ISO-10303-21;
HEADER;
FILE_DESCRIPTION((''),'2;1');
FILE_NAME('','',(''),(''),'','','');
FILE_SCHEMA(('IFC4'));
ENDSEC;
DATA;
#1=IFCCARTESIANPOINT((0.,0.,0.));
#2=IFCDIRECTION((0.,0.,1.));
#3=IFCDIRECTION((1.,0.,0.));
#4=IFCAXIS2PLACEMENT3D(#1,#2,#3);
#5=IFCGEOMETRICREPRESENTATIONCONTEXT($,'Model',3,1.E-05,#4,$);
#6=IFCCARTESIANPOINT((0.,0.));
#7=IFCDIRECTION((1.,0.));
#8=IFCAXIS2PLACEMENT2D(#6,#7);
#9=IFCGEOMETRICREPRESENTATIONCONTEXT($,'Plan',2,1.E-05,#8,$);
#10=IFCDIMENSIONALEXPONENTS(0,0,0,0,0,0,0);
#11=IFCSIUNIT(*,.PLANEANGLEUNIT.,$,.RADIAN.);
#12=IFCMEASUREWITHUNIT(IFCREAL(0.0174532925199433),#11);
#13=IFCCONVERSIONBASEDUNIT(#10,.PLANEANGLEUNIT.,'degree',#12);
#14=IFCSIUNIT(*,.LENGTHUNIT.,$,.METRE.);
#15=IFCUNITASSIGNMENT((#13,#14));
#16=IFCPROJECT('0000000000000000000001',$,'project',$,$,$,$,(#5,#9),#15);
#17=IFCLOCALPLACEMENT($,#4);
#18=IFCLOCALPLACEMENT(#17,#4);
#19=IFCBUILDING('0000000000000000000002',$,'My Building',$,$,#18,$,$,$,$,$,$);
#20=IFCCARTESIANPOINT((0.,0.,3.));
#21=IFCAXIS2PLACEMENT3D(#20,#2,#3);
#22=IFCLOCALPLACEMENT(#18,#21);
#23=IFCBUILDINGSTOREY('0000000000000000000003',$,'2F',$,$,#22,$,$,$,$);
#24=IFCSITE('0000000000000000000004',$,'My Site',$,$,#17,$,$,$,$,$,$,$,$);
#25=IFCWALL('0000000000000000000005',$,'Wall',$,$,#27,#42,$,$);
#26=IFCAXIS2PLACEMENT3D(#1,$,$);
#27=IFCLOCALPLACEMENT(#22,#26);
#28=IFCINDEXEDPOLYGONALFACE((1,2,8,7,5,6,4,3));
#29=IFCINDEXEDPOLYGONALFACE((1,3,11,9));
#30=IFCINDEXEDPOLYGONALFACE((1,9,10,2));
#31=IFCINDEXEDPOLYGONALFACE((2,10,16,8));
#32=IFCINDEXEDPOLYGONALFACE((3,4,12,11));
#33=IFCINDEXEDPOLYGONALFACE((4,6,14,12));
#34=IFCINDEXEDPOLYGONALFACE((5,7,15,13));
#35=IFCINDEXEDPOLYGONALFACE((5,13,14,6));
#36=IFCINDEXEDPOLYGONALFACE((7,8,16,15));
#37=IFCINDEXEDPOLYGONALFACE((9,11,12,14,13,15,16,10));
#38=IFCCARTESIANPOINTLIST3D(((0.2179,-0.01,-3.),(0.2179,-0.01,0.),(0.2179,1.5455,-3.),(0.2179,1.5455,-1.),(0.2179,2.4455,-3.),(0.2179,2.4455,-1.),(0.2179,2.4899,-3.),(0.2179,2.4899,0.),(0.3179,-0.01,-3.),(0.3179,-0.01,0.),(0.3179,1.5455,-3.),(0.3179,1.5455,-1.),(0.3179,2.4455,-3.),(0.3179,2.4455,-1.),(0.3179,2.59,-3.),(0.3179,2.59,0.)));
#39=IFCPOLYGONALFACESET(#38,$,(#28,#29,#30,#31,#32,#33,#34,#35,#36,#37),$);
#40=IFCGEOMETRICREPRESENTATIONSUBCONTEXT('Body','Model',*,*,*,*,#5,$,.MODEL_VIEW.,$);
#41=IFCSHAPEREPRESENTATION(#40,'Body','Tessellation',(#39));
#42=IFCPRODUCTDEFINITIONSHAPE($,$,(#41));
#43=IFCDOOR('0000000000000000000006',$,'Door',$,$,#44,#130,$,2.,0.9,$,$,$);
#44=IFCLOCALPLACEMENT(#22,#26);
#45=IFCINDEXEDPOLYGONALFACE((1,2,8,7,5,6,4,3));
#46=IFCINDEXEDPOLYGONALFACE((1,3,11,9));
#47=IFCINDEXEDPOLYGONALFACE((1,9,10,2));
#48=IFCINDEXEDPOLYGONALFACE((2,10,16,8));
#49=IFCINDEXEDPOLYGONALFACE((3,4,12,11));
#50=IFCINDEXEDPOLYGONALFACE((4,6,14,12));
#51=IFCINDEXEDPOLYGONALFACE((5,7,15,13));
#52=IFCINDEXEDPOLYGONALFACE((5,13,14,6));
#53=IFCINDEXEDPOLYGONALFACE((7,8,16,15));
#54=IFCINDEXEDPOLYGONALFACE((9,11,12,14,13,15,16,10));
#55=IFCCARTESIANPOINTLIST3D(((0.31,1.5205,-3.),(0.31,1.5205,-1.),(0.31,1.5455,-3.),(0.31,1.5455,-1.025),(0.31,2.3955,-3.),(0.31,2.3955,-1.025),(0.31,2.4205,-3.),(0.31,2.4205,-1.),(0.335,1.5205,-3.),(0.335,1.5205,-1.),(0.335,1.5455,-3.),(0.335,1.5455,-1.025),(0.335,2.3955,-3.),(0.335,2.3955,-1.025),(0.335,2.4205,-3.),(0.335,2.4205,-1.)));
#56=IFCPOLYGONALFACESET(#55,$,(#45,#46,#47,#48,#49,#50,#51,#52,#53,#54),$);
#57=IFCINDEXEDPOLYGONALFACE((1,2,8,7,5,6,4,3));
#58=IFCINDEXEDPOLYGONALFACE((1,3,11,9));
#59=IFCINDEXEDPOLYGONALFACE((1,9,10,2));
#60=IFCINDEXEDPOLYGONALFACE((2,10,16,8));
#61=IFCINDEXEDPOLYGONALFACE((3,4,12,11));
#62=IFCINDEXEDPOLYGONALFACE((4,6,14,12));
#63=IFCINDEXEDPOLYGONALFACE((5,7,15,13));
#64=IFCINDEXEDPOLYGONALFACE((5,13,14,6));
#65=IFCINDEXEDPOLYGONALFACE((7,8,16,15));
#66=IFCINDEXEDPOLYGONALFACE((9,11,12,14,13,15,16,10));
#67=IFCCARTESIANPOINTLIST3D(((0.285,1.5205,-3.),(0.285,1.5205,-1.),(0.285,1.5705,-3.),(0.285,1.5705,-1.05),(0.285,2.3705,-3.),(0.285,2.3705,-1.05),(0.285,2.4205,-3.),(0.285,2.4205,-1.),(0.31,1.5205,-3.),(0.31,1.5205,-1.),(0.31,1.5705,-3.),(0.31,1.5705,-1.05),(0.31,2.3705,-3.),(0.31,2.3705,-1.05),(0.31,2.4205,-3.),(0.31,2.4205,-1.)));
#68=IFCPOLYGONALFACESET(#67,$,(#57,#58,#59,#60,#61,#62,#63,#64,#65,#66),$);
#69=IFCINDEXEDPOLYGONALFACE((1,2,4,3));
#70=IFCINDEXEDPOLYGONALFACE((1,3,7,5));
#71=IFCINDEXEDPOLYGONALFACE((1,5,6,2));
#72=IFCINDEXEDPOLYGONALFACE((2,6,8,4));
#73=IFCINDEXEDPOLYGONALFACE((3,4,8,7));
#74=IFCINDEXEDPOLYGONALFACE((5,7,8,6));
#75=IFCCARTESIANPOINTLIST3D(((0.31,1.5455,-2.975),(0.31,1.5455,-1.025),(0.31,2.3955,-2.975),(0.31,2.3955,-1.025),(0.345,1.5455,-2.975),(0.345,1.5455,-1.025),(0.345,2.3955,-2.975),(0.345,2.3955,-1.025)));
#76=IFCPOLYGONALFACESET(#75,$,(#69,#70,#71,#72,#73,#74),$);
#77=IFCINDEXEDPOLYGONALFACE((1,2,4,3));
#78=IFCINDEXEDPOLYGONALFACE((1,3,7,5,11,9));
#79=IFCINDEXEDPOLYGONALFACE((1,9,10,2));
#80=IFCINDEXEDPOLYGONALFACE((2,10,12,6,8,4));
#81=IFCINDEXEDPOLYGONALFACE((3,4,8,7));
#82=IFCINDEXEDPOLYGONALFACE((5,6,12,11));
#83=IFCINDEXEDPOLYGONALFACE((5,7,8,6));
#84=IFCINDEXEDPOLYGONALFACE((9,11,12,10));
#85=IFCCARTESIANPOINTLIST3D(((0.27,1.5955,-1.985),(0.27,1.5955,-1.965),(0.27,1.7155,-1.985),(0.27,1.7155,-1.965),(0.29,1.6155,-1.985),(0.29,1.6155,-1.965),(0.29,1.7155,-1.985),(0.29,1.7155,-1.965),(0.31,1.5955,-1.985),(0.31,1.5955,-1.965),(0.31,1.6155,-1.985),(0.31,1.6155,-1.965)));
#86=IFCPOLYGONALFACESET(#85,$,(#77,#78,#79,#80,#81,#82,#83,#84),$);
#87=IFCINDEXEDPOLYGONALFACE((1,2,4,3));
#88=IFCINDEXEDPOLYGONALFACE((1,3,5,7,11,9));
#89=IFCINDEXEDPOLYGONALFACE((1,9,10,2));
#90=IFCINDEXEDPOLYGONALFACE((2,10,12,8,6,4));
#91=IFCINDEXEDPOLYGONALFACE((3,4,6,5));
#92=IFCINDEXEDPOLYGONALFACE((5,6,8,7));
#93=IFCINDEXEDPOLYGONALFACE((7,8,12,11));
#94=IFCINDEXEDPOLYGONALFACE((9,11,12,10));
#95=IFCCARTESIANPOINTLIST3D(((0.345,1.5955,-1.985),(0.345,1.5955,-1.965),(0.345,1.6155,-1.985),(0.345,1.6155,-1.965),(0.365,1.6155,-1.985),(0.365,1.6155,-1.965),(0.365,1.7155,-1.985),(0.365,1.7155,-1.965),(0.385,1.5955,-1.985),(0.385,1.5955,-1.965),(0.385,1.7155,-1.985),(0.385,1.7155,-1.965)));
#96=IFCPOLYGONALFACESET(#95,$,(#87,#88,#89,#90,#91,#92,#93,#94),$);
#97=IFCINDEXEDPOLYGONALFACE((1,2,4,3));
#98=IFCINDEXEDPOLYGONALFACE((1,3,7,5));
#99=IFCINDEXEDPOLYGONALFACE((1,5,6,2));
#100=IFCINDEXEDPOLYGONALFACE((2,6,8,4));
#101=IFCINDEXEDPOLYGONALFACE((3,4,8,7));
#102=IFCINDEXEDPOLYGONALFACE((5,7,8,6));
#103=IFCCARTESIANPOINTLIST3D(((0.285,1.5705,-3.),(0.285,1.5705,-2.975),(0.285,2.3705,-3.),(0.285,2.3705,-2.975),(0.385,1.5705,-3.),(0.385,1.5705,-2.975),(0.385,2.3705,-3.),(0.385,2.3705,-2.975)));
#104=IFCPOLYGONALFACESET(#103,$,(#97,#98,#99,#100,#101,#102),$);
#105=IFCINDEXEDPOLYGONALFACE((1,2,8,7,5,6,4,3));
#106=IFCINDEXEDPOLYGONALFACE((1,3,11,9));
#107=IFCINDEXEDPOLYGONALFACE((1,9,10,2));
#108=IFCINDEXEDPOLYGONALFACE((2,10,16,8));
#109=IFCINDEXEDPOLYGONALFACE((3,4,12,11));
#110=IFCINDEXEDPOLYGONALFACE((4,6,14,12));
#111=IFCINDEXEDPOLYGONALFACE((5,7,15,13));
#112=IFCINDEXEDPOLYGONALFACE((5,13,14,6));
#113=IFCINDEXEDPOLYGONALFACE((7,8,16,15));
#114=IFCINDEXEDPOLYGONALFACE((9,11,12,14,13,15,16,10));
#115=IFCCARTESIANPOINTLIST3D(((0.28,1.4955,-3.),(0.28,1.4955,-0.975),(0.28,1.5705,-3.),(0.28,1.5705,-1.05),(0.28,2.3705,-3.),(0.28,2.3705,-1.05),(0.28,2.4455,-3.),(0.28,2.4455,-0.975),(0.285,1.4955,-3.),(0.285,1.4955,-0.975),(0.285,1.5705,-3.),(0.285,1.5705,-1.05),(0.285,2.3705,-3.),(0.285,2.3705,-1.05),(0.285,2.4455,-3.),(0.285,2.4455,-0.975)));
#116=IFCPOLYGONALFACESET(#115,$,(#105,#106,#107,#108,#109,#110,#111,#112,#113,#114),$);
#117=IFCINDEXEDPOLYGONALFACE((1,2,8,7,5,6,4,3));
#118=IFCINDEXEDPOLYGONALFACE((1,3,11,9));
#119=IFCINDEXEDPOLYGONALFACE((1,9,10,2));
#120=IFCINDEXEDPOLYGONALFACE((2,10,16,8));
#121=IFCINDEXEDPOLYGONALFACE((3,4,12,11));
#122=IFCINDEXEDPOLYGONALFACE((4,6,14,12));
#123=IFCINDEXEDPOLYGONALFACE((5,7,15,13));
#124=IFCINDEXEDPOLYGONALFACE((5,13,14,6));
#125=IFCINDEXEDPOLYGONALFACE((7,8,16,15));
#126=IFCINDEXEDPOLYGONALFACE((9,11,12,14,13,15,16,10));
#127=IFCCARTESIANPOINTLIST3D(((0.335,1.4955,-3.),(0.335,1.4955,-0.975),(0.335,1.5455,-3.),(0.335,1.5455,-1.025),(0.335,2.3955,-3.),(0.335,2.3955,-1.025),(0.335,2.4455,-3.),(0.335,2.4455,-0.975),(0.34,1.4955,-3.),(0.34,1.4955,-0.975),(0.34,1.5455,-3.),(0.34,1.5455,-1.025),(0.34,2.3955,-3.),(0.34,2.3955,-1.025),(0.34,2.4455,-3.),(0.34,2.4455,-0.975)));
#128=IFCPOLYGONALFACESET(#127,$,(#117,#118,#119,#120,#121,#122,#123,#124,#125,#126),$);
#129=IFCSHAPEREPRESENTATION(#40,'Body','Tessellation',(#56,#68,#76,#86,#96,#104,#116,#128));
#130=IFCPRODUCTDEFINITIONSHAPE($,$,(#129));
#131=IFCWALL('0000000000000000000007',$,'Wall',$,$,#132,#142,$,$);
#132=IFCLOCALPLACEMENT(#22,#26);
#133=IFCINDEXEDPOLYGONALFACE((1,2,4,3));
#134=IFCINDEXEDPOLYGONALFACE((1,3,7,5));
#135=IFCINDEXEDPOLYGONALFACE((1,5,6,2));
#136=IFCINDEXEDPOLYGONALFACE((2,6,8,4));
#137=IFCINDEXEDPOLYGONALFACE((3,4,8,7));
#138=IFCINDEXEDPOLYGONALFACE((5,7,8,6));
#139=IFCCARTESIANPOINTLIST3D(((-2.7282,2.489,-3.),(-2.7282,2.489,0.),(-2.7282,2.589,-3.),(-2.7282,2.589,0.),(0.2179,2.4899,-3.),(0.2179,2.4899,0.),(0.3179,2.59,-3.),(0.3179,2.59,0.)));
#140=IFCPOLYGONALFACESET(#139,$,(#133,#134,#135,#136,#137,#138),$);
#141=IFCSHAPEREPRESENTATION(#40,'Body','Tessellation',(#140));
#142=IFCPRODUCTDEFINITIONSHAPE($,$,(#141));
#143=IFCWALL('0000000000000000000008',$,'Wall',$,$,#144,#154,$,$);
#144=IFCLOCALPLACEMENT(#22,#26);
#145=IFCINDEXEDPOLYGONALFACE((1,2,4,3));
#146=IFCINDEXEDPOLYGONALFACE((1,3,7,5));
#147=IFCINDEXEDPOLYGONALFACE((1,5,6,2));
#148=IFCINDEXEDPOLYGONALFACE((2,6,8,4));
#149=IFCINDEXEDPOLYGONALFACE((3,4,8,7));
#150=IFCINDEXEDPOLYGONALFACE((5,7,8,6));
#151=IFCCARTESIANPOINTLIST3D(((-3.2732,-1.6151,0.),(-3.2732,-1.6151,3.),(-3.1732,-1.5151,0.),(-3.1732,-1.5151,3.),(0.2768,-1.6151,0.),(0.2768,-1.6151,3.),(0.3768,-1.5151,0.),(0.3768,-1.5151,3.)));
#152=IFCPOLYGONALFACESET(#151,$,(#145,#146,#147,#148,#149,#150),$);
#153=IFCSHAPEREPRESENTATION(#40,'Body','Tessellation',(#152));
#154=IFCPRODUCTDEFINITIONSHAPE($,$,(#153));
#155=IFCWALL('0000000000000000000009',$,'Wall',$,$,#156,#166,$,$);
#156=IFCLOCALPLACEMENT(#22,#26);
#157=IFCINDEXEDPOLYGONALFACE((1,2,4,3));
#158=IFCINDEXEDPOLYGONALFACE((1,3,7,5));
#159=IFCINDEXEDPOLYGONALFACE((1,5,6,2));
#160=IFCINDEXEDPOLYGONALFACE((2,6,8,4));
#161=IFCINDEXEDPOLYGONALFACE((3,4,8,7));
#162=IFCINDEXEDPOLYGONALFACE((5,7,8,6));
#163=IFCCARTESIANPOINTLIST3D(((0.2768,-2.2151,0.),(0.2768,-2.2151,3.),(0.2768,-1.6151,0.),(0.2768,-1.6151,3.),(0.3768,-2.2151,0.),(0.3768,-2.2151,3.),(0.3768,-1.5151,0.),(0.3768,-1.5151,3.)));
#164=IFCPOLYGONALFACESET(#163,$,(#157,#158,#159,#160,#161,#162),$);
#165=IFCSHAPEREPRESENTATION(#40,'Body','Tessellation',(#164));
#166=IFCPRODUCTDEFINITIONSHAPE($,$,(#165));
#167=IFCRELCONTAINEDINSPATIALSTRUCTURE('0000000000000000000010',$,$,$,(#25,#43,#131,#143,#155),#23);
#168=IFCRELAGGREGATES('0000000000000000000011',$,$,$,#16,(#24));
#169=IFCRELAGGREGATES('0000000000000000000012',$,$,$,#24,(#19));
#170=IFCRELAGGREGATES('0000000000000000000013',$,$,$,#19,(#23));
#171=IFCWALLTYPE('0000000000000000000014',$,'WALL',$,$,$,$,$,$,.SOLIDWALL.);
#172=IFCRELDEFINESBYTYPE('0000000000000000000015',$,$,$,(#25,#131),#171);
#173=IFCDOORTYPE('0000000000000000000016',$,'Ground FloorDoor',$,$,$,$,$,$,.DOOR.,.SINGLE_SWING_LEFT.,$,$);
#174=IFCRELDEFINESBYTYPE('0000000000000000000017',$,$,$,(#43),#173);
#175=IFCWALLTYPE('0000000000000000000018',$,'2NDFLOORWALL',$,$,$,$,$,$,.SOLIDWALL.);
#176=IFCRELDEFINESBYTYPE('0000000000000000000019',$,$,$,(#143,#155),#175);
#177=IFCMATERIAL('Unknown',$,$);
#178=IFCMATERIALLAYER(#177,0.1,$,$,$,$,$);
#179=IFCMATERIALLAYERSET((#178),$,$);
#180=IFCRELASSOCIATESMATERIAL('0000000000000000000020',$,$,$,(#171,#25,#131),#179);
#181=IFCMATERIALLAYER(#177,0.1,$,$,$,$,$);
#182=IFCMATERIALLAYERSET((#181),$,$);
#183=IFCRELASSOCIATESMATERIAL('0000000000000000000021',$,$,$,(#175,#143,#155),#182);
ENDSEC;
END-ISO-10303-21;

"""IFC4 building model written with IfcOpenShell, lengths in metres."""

from ifc_helpers import new_model, entity, si_unit, converted_unit, frame, origin_with_axes, origin_2d_with_axis, place, context, subcontext, project, spatial, line, indexed_curve, outline, extrude, shape, source, transform, mapped, material, layer, layer_set, layer_usage, type_object, type_shapes, element, fill, save


model = new_model("IFC4")

# Units and contexts
model_context = context("Model", 3, precision=1e-05, world=origin_with_axes())
plan_context = context("Plan", 2, precision=1e-05, world=origin_2d_with_axis())
body_context_1 = subcontext(model_context, "Body", "Model", "MODEL_VIEW")
body_context_2 = subcontext(plan_context, "Body", "Plan", "PLAN_VIEW")
ifc_project = project(units=[converted_unit("PLANEANGLEUNIT", "degree", entity("IfcReal", 0.0174532925199433), si_unit("PLANEANGLEUNIT", "RADIAN"), dimensions=[0, 0, 0, 0, 0, 0, 0]), si_unit("LENGTHUNIT", "METRE")], contexts=[model_context, plan_context])

# Site, building, storey
site_placement = place(None, origin_with_axes())
site = spatial("IfcSite", under=ifc_project, at=site_placement, Name="My Site")
building_placement = place(site_placement, origin_with_axes())
building = spatial("IfcBuilding", under=site, at=building_placement, Name="My Building")
storey_placement = place(building_placement, frame((0.0, 0.0, 3.0), z_axis=(0.0, 0.0, 1.0), x_axis=(1.0, 0.0, 0.0)))
storey = spatial("IfcBuildingStorey", under=building, at=storey_placement, Name="2F")

# Shared definitions
ifc_material = material(Name="Unknown")
ifc_layer_1 = layer(ifc_material, 0.1)
ifc_layer_set_1 = layer_set([ifc_layer_1])
wall_type_1 = type_object("IfcWallType", Name="WALL", PredefinedType="SOLIDWALL", material=ifc_layer_set_1)
shared_shape_1 = source(origin_with_axes(), body_context_1, "Body", "SweptSolid", [
    extrude(outline(indexed_curve([(0.0, 0.0), (0.9, 0.0), (0.9, 2.0), (0.0, 2.0)], segments=[line(1, 2, 3, 4, 1)])), frame((0.0, -0.6, 0.0), z_axis=(0.0, -1.0, 0.0), x_axis=(1.0, 0.0, 0.0)), (0.0, 0.0, -1.0), 1.2),
])
door_type = type_object("IfcDoorType", Name="Ground FloorDoor", OperationType="SINGLE_SWING_LEFT", PredefinedType="DOOR")
shared_shape_2 = source(origin_with_axes(), body_context_1, "Body", "SweptSolid", [
    extrude(outline(indexed_curve([(0.0, 0.0), (0.0, 2.0), (0.9, 2.0), (0.9, 0.0), (0.875, 0.0), (0.875, 1.975), (0.025, 1.975), (0.025, 0.0)], segments=[line(1, 2, 3, 4, 5, 6, 7, 8, 1)])), frame((0.0, 0.025, 0.0), z_axis=(0.0, -1.0, 0.0), x_axis=(1.0, 0.0, 0.0)), (0.0, 0.0, -1.0), 0.025),
    extrude(outline(indexed_curve([(0.0, 0.0), (0.0, 2.0), (0.9, 2.0), (0.9, 0.0), (0.85, 0.0), (0.85, 1.95), (0.05, 1.95), (0.05, 0.0)], segments=[line(1, 2, 3, 4, 5, 6, 7, 8, 1)])), frame((0.0, 0.0, 0.0), z_axis=(0.0, -1.0, 0.0), x_axis=(1.0, 0.0, 0.0)), (0.0, 0.0, -1.0), 0.025),
    extrude(outline(indexed_curve([(0.0, 0.0), (0.85, 0.0), (0.85, 0.035), (0.0, 0.035)], segments=[line(1, 2, 3, 4, 1)])), frame((0.025, 0.025, 0.025), z_axis=(0.0, 0.0, 1.0), x_axis=(1.0, 0.0, 0.0)), (0.0, 0.0, 1.0), 1.95),
    extrude(outline(indexed_curve([(0.0, 0.0), (0.0, -0.04), (-0.12, -0.04), (-0.12, -0.02), (-0.02, -0.02), (-0.02, 0.0)], segments=[line(1, 2, 3, 4, 5, 6, 1)])), frame((0.825, 0.025, 1.015), z_axis=(0.0, 0.0, 1.0), x_axis=(1.0, 0.0, 0.0)), (0.0, 0.0, 1.0), 0.02),
    extrude(outline(indexed_curve([(0.0, 0.0), (0.0, 0.04), (-0.12, 0.04), (-0.12, 0.02), (-0.02, 0.02), (-0.02, 0.0)], segments=[line(1, 2, 3, 4, 5, 6, 1)])), frame((0.825, 0.06, 1.015), z_axis=(0.0, 0.0, 1.0), x_axis=(1.0, 0.0, 0.0)), (0.0, 0.0, 1.0), 0.02),
    extrude(outline(indexed_curve([(0.0, 0.0), (0.8, 0.0), (0.8, 0.1), (0.0, 0.1)], segments=[line(1, 2, 3, 4, 1)])), frame((0.05, 0.0, 0.0), z_axis=(0.0, 0.0, 1.0), x_axis=(1.0, 0.0, 0.0)), (0.0, 0.0, 1.0), 0.025),
    extrude(outline(indexed_curve([(0.0, 0.0), (0.0, 2.025), (0.95, 2.025), (0.95, 0.0), (0.875, 0.0), (0.875, 1.95), (0.075, 1.95), (0.075, 0.0)], segments=[line(1, 2, 3, 4, 5, 6, 7, 8, 1)])), frame((-0.025, -0.005, 0.0), z_axis=(0.0, -1.0, 0.0), x_axis=(1.0, 0.0, 0.0)), (0.0, 0.0, -1.0), 0.005),
    extrude(outline(indexed_curve([(0.0, 0.0), (0.0, 2.025), (0.95, 2.025), (0.95, 0.0), (0.9, 0.0), (0.9, 1.975), (0.05, 1.975), (0.05, 0.0)], segments=[line(1, 2, 3, 4, 5, 6, 7, 8, 1)])), frame((-0.025, 0.05, 0.0), z_axis=(0.0, -1.0, 0.0), x_axis=(1.0, 0.0, 0.0)), (0.0, 0.0, -1.0), 0.005),
])
shared_shape_3 = source(origin_with_axes(), body_context_2, "Body", "Curve2D", [
    entity("IfcIndexedPolyCurve", entity("IfcCartesianPointList2D", [[0.0, 0.0], [0.0, 0.05], [0.025, 0.05], [0.025, 0.025], [0.05, 0.025], [0.05, 0.0]]), [entity("IfcLineIndex", [1, 2, 3, 4, 5, 6, 1])]),
    entity("IfcIndexedPolyCurve", entity("IfcCartesianPointList2D", [[0.9, 0.0], [0.9, 0.05], [0.875, 0.05], [0.875, 0.025], [0.85, 0.025], [0.85, 0.0]]), [entity("IfcLineIndex", [1, 2, 3, 4, 5, 6, 1])]),
    entity("IfcTrimmedCurve", entity("IfcEllipse", entity("IfcAxis2Placement2D", entity("IfcCartesianPoint", [0.06, 0.05]), entity("IfcDirection", [1.0, 0.0])), 0.815, 0.85), [entity("IfcCartesianPoint", [0.875, 0.05])], [entity("IfcCartesianPoint", [0.06, 0.9])], True, "CARTESIAN"),
    entity("IfcIndexedPolyCurve", entity("IfcCartesianPointList2D", [[0.025, 0.05], [0.06, 0.05], [0.06, 0.9], [0.025, 0.9]]), [entity("IfcLineIndex", [1, 2, 3, 4, 1])]),
])
type_shapes(door_type, [shared_shape_2, shared_shape_3])

# Wall, opening, door
ifc_layer_usage_1 = layer_usage(ifc_layer_set_1, "AXIS2", "POSITIVE", 0.0)
wall_1_placement = place(storey_placement, frame((0.3179, -0.01, -3.0), z_axis=(0.0, 0.0, 1.0), x_axis=(0.0, 1.0, 0.0)))
wall_1 = element("IfcWall", 1, at=wall_1_placement, inside=storey, type_object=wall_type_1, material=ifc_layer_usage_1, Name="Wall", context=body_context_1, shape_type="SweptSolid", body=[
    extrude(outline(indexed_curve([(0.0, 0.0), (0.0, 0.1), (2.5, 0.1), (2.6, 0.0)], segments=[line(1, 2, 3, 4, 1)])), origin_with_axes(), (0.0, 0.0, 1.0), 3.0),
])
opening_1_placement = place(wall_1_placement, frame((1.5555, 0.0, 0.0), z_axis=(0.0, 0.0, 1.0), x_axis=(1.0, 0.0, 0.0)))
opening_1 = element("IfcOpeningElement", 2, at=opening_1_placement, cuts=wall_1, PredefinedType="OPENING", context=body_context_1, shape_type="MappedRepresentation", body=[
    mapped(shared_shape_1, transform((0.0, 0.0, 0.0), x_axis=(1.0, 0.0, 0.0), y_axis=(0.0, 1.0, 0.0), z_axis=(0.0, 0.0, 1.0), scale=1.0)),
])
door_1_placement = place(opening_1_placement, frame((0.875, 0.033, 0.0), z_axis=(0.0, 0.0, 1.0), x_axis=(-1.0, 0.0, 0.0)))
door_1 = element("IfcDoor", 3, at=door_1_placement, inside=storey, type_object=door_type, Name="Door", OverallHeight=2.0, OverallWidth=0.9, shapes=[
    shape(body_context_1, "Body", "MappedRepresentation", [mapped(shared_shape_2, transform((0.0, 0.0, 0.0), x_axis=(1.0, 0.0, 0.0), y_axis=(0.0, 1.0, 0.0), z_axis=(0.0, 0.0, 1.0), scale=1.0))]),
    shape(body_context_2, "Body", "MappedRepresentation", [mapped(shared_shape_3, transform((0.0, 0.0, 0.0), x_axis=(1.0, 0.0, 0.0), y_axis=(0.0, 1.0, 0.0), z_axis=(0.0, 0.0, 1.0), scale=1.0))]),
])
fill(opening_1, door_1)

# Wall
ifc_layer_usage_2 = layer_usage(ifc_layer_set_1, "AXIS2", "POSITIVE", 0.0)
wall_2_placement = place(storey_placement, frame((0.3179, 2.59, -3.0), z_axis=(0.0, 0.0, 1.0), x_axis=(-1.0, -0.000321, 0.0)))
element("IfcWall", 4, at=wall_2_placement, inside=storey, type_object=wall_type_1, material=ifc_layer_usage_2, Name="Wall", context=body_context_1, shape_type="SweptSolid", body=[
    extrude(outline(indexed_curve([(0.0, 0.0), (0.1, 0.1), (3.0462, 0.1), (3.0462, 0.0)], segments=[line(1, 2, 3, 4, 1)])), origin_with_axes(), (0.0, 0.0, 1.0), 3.0),
])

# Walls
ifc_layer_2 = layer(ifc_material, 0.1)
ifc_layer_set_2 = layer_set([ifc_layer_2])
ifc_layer_usage_3 = layer_usage(ifc_layer_set_2, "AXIS2", "POSITIVE", 0.0)
wall_type_2 = type_object("IfcWallType", Name="2NDFLOORWALL", PredefinedType="SOLIDWALL", material=ifc_layer_set_2)
wall_3_placement = place(storey_placement, frame((-3.2732, -1.6151, 0.0), z_axis=(0.0, 0.0, 1.0), x_axis=(1.0, 0.0, 0.0)))
element("IfcWall", 5, at=wall_3_placement, inside=storey, type_object=wall_type_2, material=ifc_layer_usage_3, Name="Wall", context=body_context_1, shape_type="SweptSolid", body=[
    extrude(outline(indexed_curve([(0.0, 0.0), (0.1, 0.1), (3.65, 0.1), (3.55, 0.0)], segments=[line(1, 2, 3, 4, 1)])), origin_with_axes(), (0.0, 0.0, 1.0), 3.0),
])
ifc_layer_usage_4 = layer_usage(ifc_layer_set_2, "AXIS2", "POSITIVE", 0.0)
wall_4_placement = place(storey_placement, frame((0.2768, -1.6151, 0.0), z_axis=(0.0, 0.0, 1.0), x_axis=(0.0, -1.0, 0.0)))
element("IfcWall", 6, at=wall_4_placement, inside=storey, type_object=wall_type_2, material=ifc_layer_usage_4, Name="Wall", context=body_context_1, shape_type="SweptSolid", body=[
    extrude(outline(indexed_curve([(0.0, 0.0), (-0.1, 0.1), (0.6, 0.1), (0.6, 0.0)], segments=[line(1, 2, 3, 4, 1)])), origin_with_axes(), (0.0, 0.0, 1.0), 3.0),
])

save(model, "model.ifc")
